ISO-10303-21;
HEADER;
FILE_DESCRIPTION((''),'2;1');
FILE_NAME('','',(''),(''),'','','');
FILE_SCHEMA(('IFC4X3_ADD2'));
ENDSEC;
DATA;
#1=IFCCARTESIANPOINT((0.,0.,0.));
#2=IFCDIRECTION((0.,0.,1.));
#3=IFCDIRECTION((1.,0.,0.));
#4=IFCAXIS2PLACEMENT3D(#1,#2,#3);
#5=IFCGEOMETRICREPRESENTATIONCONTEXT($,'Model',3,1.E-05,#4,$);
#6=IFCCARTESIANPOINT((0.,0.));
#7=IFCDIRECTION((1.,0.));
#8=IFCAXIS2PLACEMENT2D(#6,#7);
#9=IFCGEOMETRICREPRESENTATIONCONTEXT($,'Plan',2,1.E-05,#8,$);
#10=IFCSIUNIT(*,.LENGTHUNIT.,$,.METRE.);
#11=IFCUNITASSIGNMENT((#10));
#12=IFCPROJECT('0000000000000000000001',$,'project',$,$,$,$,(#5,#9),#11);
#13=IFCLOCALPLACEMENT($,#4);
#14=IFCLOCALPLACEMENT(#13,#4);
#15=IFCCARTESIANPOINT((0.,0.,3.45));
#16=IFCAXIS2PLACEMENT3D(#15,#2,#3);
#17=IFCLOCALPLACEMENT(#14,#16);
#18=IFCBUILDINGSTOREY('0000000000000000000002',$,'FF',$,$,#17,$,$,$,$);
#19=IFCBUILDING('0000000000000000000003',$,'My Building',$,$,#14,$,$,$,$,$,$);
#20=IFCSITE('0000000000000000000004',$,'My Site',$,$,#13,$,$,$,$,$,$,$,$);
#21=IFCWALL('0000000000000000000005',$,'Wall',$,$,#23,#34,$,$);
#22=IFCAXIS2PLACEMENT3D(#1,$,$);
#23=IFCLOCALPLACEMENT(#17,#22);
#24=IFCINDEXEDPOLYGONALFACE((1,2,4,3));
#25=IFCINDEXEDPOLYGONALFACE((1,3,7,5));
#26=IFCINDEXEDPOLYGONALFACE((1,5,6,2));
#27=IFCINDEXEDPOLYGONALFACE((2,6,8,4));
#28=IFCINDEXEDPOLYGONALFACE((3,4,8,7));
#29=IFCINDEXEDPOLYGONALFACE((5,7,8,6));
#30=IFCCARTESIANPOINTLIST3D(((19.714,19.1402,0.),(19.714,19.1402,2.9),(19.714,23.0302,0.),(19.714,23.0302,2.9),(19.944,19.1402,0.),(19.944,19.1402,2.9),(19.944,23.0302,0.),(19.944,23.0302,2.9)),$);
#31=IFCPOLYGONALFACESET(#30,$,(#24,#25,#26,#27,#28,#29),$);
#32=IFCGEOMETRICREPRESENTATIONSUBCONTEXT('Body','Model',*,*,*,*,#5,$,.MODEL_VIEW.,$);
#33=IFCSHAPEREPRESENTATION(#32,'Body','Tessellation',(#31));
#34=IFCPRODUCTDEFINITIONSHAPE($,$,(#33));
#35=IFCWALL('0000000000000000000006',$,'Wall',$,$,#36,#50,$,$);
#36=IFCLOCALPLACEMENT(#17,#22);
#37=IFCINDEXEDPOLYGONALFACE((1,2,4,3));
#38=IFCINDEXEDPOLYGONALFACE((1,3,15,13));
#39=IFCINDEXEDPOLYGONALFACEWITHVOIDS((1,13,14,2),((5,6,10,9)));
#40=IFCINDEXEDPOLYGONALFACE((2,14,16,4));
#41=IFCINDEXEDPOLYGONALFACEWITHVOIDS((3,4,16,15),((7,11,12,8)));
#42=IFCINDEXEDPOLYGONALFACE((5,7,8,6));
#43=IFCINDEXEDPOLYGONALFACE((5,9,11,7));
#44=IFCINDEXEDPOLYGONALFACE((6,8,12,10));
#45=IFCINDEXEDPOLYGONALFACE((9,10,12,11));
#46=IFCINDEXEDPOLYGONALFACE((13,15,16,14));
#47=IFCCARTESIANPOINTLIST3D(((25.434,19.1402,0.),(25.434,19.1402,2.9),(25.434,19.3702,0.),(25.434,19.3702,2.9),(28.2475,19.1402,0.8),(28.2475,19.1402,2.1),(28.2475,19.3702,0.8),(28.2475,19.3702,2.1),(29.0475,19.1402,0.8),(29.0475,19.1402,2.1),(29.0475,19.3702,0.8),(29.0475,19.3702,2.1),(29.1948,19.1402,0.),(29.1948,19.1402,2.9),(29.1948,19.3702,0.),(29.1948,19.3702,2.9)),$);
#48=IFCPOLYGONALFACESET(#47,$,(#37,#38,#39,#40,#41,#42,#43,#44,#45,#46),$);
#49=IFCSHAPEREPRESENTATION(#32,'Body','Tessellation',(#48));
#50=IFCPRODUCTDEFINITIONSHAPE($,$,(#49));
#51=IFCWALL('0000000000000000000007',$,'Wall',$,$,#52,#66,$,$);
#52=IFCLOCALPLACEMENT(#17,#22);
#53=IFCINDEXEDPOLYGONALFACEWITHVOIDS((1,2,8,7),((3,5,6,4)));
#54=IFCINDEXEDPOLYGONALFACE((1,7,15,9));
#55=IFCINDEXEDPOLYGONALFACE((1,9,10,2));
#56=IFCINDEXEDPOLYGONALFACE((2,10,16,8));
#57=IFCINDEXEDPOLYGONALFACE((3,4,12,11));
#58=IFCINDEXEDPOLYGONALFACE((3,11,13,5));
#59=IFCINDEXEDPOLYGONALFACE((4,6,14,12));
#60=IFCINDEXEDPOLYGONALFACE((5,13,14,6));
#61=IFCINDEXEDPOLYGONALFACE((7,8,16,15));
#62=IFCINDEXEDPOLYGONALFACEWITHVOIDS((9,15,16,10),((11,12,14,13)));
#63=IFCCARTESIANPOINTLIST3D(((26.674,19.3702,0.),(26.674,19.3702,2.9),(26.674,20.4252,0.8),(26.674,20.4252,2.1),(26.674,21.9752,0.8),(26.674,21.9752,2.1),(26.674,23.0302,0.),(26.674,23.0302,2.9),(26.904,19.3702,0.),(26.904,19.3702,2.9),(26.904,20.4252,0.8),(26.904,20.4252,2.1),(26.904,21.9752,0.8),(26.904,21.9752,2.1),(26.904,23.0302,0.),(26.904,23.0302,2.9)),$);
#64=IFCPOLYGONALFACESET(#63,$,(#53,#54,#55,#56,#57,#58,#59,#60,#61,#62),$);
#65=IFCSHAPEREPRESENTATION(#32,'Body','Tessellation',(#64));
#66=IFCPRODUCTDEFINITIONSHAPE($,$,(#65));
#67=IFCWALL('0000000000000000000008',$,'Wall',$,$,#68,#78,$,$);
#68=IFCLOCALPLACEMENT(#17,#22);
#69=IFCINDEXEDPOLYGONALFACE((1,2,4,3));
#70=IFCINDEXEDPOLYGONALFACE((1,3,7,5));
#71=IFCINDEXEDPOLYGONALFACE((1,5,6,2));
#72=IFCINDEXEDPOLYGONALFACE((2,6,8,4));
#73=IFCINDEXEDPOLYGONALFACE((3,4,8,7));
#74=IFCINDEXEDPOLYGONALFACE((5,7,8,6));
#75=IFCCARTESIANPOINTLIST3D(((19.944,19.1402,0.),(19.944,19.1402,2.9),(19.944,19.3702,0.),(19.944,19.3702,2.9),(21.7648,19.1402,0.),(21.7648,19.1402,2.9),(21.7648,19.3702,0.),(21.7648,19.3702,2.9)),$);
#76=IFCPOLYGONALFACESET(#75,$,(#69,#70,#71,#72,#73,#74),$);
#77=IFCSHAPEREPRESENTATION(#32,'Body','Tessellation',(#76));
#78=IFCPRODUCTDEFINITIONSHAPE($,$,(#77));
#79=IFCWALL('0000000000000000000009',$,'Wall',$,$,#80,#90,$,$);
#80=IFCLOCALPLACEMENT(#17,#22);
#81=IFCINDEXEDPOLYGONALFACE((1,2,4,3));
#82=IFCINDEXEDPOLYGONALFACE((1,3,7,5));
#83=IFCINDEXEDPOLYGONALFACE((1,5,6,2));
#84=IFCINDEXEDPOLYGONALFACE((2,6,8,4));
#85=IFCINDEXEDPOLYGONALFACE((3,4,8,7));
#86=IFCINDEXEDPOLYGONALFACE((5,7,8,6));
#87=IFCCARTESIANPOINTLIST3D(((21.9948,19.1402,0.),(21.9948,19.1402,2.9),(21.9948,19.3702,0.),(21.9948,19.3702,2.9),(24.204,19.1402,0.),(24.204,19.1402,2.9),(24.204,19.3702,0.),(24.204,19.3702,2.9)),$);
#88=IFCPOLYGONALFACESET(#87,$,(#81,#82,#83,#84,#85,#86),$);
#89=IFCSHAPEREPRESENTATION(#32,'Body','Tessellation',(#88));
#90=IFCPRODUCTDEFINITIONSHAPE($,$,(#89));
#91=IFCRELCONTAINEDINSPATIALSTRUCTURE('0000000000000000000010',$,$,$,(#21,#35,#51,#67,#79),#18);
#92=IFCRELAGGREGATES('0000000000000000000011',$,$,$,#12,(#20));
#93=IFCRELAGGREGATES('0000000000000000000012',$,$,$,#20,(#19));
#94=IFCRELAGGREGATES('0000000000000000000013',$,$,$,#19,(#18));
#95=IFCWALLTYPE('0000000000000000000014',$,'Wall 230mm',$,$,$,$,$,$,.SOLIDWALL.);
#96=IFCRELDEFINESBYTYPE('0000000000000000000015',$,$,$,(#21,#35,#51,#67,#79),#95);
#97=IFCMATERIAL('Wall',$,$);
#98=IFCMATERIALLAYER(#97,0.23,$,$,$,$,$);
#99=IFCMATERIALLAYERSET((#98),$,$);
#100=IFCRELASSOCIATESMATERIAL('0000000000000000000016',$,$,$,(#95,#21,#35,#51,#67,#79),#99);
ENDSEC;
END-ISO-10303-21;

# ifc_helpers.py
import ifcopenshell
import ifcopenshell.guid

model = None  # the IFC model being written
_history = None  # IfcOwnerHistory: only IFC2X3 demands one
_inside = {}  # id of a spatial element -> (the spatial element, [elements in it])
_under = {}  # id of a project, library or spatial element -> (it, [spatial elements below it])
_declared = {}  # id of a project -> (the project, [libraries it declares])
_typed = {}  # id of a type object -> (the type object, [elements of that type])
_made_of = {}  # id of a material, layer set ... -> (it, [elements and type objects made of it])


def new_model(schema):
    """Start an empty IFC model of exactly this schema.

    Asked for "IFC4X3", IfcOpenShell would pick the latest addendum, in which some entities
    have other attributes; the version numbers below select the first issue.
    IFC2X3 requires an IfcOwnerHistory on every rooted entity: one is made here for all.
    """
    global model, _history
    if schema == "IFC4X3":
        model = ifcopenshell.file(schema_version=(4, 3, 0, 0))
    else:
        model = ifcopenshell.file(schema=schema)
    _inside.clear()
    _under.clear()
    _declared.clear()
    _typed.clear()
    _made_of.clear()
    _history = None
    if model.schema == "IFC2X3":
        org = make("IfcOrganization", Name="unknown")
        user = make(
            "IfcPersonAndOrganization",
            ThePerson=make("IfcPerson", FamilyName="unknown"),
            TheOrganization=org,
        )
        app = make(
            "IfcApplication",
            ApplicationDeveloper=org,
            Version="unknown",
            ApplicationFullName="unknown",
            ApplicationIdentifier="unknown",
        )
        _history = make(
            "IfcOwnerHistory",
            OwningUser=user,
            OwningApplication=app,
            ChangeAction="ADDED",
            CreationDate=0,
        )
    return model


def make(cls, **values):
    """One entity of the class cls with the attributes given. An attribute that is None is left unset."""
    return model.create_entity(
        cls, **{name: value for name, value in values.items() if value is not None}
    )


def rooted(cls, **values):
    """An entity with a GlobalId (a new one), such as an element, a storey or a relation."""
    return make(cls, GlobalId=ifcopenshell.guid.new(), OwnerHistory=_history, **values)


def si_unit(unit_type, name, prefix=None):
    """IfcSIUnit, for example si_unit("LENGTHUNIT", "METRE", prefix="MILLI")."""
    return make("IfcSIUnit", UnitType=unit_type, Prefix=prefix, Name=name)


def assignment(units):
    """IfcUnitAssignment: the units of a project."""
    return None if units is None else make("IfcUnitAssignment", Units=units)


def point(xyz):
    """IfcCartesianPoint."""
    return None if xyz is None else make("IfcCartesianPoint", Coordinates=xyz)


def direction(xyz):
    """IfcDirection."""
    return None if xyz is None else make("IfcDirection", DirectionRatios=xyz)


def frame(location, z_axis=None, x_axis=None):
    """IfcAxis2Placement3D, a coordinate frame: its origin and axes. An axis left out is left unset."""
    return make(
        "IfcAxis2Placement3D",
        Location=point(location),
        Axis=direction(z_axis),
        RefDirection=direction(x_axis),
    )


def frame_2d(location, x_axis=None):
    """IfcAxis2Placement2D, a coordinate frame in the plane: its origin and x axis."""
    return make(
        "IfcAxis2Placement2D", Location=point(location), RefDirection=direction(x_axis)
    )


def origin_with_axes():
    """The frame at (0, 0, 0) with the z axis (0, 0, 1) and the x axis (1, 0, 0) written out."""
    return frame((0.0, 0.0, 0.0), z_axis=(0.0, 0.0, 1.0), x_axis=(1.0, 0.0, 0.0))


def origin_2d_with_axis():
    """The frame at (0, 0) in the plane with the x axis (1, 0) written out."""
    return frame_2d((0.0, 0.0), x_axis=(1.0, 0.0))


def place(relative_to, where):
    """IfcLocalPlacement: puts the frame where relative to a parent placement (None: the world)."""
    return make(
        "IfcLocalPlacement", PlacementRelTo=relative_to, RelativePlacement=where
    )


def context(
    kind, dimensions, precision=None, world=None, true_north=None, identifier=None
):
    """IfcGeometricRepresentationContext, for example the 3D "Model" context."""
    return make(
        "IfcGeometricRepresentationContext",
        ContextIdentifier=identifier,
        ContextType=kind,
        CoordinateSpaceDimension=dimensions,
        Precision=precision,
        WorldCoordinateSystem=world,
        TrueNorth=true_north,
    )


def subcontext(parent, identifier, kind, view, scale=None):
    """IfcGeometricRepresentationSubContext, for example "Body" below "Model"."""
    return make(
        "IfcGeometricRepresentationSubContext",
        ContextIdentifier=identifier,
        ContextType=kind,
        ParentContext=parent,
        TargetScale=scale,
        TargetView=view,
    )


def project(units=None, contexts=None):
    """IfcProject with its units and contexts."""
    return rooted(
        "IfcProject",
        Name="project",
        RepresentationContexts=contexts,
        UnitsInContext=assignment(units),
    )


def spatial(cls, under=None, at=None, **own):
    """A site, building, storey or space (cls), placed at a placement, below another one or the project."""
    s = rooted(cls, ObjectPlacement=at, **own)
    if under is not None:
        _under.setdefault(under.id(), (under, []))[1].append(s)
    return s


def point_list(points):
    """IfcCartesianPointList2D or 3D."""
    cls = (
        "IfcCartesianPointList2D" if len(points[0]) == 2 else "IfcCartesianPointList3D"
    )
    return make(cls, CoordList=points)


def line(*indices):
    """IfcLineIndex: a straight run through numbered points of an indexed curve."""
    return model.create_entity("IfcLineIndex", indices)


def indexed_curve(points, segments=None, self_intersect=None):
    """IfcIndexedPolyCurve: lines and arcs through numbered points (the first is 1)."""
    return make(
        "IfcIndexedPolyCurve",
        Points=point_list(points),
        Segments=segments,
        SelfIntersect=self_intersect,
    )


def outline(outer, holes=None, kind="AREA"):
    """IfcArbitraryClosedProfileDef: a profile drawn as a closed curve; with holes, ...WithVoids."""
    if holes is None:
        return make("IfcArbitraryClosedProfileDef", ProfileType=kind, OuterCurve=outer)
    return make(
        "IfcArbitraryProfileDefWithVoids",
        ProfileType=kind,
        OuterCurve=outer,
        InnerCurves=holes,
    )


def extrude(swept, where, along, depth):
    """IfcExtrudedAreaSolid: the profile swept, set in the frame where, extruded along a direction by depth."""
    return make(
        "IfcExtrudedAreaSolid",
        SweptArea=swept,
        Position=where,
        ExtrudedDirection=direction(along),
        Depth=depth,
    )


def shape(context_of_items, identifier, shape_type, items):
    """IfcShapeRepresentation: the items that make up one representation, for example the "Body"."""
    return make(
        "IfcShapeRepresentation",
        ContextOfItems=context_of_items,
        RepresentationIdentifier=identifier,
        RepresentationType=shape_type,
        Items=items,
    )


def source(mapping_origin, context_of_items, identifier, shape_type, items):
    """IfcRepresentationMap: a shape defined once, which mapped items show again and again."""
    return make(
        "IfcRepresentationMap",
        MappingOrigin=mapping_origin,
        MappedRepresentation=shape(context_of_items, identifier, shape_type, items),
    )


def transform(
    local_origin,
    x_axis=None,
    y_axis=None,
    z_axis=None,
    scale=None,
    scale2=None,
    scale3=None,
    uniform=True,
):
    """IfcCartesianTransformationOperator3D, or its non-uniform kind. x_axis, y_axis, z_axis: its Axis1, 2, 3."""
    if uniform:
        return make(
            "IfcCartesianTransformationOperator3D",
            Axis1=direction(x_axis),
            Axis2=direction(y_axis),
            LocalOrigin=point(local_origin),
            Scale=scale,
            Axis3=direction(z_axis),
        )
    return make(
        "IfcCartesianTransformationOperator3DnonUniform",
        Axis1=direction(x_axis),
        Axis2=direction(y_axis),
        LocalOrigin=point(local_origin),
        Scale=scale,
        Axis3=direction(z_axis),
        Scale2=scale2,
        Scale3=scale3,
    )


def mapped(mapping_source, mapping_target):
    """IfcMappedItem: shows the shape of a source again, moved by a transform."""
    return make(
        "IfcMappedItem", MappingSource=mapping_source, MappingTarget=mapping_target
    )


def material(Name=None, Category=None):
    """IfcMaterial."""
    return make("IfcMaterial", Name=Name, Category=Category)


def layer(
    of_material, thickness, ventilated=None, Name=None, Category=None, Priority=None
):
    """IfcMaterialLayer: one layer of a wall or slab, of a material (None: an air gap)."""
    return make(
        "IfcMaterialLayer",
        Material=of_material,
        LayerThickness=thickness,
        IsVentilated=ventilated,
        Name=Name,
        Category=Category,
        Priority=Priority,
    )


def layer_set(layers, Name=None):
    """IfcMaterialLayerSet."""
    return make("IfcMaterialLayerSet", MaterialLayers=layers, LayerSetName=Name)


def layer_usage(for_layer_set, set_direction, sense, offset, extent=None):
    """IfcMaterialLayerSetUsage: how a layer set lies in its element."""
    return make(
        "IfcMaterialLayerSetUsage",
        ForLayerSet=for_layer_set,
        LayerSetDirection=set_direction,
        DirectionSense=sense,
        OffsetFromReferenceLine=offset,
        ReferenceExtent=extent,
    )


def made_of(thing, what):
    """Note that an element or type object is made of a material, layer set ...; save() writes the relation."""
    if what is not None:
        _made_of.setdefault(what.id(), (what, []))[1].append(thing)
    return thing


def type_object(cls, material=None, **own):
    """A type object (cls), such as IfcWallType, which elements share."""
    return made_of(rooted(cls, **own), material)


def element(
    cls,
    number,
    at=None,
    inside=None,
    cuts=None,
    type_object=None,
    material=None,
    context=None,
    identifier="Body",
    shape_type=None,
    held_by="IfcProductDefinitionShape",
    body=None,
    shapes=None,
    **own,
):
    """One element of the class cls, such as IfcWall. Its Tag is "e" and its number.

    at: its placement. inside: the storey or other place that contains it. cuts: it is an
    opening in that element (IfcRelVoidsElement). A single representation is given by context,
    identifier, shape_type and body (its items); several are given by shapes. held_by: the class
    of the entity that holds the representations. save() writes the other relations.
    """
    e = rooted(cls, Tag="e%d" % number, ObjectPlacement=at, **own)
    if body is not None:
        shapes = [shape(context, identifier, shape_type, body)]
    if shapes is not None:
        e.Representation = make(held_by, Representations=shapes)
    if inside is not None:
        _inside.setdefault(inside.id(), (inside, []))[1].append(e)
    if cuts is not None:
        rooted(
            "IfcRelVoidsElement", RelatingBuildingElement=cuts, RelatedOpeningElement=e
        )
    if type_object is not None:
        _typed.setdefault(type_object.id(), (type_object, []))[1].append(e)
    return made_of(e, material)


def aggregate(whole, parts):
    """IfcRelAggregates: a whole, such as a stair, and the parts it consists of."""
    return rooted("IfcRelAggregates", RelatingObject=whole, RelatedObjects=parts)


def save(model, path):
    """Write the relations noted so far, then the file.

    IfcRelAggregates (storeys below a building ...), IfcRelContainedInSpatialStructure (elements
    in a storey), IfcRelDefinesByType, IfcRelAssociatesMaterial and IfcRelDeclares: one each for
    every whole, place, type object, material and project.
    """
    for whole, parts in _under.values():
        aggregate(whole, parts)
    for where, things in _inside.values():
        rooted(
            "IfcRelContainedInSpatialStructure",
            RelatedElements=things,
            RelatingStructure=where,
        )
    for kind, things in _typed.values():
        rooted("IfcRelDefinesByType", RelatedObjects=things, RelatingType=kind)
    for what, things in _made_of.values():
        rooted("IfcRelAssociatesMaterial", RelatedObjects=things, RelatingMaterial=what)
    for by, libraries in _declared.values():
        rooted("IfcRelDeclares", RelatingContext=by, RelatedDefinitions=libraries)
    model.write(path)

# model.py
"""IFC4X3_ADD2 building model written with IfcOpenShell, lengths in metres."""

from ifc_helpers import new_model, si_unit, frame, origin_with_axes, origin_2d_with_axis, place, context, subcontext, project, spatial, line, indexed_curve, outline, extrude, source, transform, mapped, material, layer, layer_set, layer_usage, type_object, element, save


model = new_model("IFC4X3_ADD2")

# Units and contexts
model_context = context("Model", 3, precision=1e-05, world=origin_with_axes())
plan_context = context("Plan", 2, precision=1e-05, world=origin_2d_with_axis())
body_context_1 = subcontext(model_context, "Body", "Model", "MODEL_VIEW")
ifc_project = project(units=[si_unit("LENGTHUNIT", "METRE")], contexts=[model_context, plan_context])

# Site, building, storey
site_placement = place(None, origin_with_axes())
site = spatial("IfcSite", under=ifc_project, at=site_placement, Name="My Site")
building_placement = place(site_placement, origin_with_axes())
building = spatial("IfcBuilding", under=site, at=building_placement, Name="My Building")
storey_placement = place(building_placement, frame((0.0, 0.0, 3.45), z_axis=(0.0, 0.0, 1.0), x_axis=(1.0, 0.0, 0.0)))
storey = spatial("IfcBuildingStorey", under=building, at=storey_placement, Name="FF")

# Shared definitions
ifc_material = material(Name="Wall")

# Shared definitions
ifc_layer_1 = layer(ifc_material, 0.23)
ifc_layer_set_1 = layer_set([ifc_layer_1])
wall_type_1 = type_object("IfcWallType", Name="Wall 230mm", PredefinedType="SOLIDWALL", material=ifc_layer_set_1)
shared_shape_1 = source(origin_with_axes(), body_context_1, "Body", "SweptSolid", [
    extrude(outline(indexed_curve([(0.0, 0.0), (1.55, 0.0), (1.55, 1.3), (0.0, 1.3)], segments=[line(1, 2, 3, 4, 1)])), frame((-0.775, -0.6, 0.0), z_axis=(0.0, -1.0, 0.0), x_axis=(1.0, 0.0, 0.0)), (0.0, 0.0, -1.0), 1.2),
])

# Wall
ifc_layer_usage_1 = layer_usage(ifc_layer_set_1, "AXIS2", "POSITIVE", 0.0)
wall_1_placement = place(storey_placement, frame((19.944, 19.1402, 0.0), z_axis=(0.0, 0.0, 1.0), x_axis=(0.000001, 1.0, 0.0)))
element("IfcWall", 1, at=wall_1_placement, inside=storey, type_object=wall_type_1, material=ifc_layer_usage_1, Name="Wall", context=body_context_1, shape_type="SweptSolid", body=[
    extrude(outline(indexed_curve([(0.0, 0.0), (0.0, 0.23), (3.89, 0.23), (3.89, 0.0), (0.0, 0.0)], self_intersect=False)), origin_with_axes(), (0.0, 0.0, 1.0), 2.9),
])

# Walls, openings
ifc_layer_usage_2 = layer_usage(ifc_layer_set_1, "AXIS2", "POSITIVE", 0.0)
wall_2_placement = place(storey_placement, frame((29.1948, 19.3702, 0.0), z_axis=(0.0, 0.0, 1.0), x_axis=(-1.0, 0.0, 0.0)))
wall_2 = element("IfcWall", 2, at=wall_2_placement, inside=storey, type_object=wall_type_1, material=ifc_layer_usage_2, Name="Wall", context=body_context_1, shape_type="SweptSolid", body=[
    extrude(outline(indexed_curve([(0.0, 0.0), (0.0, 0.23), (3.7608, 0.23), (3.7608, 0.0), (0.0, 0.0)], self_intersect=False)), origin_with_axes(), (0.0, 0.0, 1.0), 2.9),
])
shared_shape_2 = source(origin_with_axes(), body_context_1, "Body", "SweptSolid", [
    extrude(outline(indexed_curve([(0.0, 0.0), (0.8, 0.0), (0.8, 1.3), (0.0, 1.3)], segments=[line(1, 2, 3, 4, 1)])), frame((-0.4, -0.6, 0.0), z_axis=(0.0, -1.0, 0.0), x_axis=(1.0, 0.0, 0.0)), (0.0, 0.0, -1.0), 1.2),
])
opening_1_placement = place(wall_2_placement, frame((0.5473, 0.0, 0.8), z_axis=(0.0, 0.0, 1.0), x_axis=(1.0, 0.0, 0.0)))
element("IfcOpeningElement", 3, at=opening_1_placement, cuts=wall_2, PredefinedType="OPENING", context=body_context_1, shape_type="MappedRepresentation", body=[
    mapped(shared_shape_2, transform((0.0, 0.0, 0.0), x_axis=(1.0, 0.0, 0.0), y_axis=(0.0, 1.0, 0.0), z_axis=(0.0, 0.0, 1.0), scale=1.0)),
])
ifc_layer_usage_3 = layer_usage(ifc_layer_set_1, "AXIS2", "POSITIVE", 0.0)
wall_3_placement = place(storey_placement, frame((26.904, 19.3702, 0.0), z_axis=(0.0, 0.0, 1.0), x_axis=(0.000001, 1.0, 0.0)))
wall_3 = element("IfcWall", 4, at=wall_3_placement, inside=storey, type_object=wall_type_1, material=ifc_layer_usage_3, Name="Wall", context=body_context_1, shape_type="SweptSolid", body=[
    extrude(outline(indexed_curve([(0.0, 0.0), (0.0, 0.23), (3.66, 0.23), (3.66, 0.0), (0.0, 0.0)], self_intersect=False)), origin_with_axes(), (0.0, 0.0, 1.0), 2.9),
])
opening_2_placement = place(wall_3_placement, frame((1.83, 0.0, 0.8), z_axis=(0.0, 0.0, 1.0), x_axis=(1.0, 0.0, 0.0)))
element("IfcOpeningElement", 5, at=opening_2_placement, cuts=wall_3, PredefinedType="OPENING", context=body_context_1, shape_type="MappedRepresentation", body=[
    mapped(shared_shape_1, transform((0.0, 0.0, 0.0), x_axis=(1.0, 0.0, 0.0), y_axis=(0.0, 1.0, 0.0), z_axis=(0.0, 0.0, 1.0), scale=1.0)),
])

# Walls
ifc_layer_usage_4 = layer_usage(ifc_layer_set_1, "AXIS2", "POSITIVE", 0.0)
wall_4_placement = place(storey_placement, frame((21.7648, 19.3702, 0.0), z_axis=(0.0, 0.0, 1.0), x_axis=(-1.0, 0.0, 0.0)))
element("IfcWall", 6, at=wall_4_placement, inside=storey, type_object=wall_type_1, material=ifc_layer_usage_4, Name="Wall", context=body_context_1, shape_type="SweptSolid", body=[
    extrude(outline(indexed_curve([(0.0, 0.0), (0.0, 0.23), (1.8208, 0.23), (1.8208, 0.0), (0.0, 0.0)], self_intersect=False)), origin_with_axes(), (0.0, 0.0, 1.0), 2.9),
])
ifc_layer_usage_5 = layer_usage(ifc_layer_set_1, "AXIS2", "POSITIVE", 0.0)
wall_5_placement = place(storey_placement, frame((24.204, 19.3702, 0.0), z_axis=(0.0, 0.0, 1.0), x_axis=(-1.0, 0.0, 0.0)))
element("IfcWall", 7, at=wall_5_placement, inside=storey, type_object=wall_type_1, material=ifc_layer_usage_5, Name="Wall", context=body_context_1, shape_type="SweptSolid", body=[
    extrude(outline(indexed_curve([(0.0, 0.0), (0.0, 0.23), (2.2092, 0.23), (2.2092, 0.0), (0.0, 0.0)], self_intersect=False)), origin_with_axes(), (0.0, 0.0, 1.0), 2.9),
])

save(model, "model.ifc")
